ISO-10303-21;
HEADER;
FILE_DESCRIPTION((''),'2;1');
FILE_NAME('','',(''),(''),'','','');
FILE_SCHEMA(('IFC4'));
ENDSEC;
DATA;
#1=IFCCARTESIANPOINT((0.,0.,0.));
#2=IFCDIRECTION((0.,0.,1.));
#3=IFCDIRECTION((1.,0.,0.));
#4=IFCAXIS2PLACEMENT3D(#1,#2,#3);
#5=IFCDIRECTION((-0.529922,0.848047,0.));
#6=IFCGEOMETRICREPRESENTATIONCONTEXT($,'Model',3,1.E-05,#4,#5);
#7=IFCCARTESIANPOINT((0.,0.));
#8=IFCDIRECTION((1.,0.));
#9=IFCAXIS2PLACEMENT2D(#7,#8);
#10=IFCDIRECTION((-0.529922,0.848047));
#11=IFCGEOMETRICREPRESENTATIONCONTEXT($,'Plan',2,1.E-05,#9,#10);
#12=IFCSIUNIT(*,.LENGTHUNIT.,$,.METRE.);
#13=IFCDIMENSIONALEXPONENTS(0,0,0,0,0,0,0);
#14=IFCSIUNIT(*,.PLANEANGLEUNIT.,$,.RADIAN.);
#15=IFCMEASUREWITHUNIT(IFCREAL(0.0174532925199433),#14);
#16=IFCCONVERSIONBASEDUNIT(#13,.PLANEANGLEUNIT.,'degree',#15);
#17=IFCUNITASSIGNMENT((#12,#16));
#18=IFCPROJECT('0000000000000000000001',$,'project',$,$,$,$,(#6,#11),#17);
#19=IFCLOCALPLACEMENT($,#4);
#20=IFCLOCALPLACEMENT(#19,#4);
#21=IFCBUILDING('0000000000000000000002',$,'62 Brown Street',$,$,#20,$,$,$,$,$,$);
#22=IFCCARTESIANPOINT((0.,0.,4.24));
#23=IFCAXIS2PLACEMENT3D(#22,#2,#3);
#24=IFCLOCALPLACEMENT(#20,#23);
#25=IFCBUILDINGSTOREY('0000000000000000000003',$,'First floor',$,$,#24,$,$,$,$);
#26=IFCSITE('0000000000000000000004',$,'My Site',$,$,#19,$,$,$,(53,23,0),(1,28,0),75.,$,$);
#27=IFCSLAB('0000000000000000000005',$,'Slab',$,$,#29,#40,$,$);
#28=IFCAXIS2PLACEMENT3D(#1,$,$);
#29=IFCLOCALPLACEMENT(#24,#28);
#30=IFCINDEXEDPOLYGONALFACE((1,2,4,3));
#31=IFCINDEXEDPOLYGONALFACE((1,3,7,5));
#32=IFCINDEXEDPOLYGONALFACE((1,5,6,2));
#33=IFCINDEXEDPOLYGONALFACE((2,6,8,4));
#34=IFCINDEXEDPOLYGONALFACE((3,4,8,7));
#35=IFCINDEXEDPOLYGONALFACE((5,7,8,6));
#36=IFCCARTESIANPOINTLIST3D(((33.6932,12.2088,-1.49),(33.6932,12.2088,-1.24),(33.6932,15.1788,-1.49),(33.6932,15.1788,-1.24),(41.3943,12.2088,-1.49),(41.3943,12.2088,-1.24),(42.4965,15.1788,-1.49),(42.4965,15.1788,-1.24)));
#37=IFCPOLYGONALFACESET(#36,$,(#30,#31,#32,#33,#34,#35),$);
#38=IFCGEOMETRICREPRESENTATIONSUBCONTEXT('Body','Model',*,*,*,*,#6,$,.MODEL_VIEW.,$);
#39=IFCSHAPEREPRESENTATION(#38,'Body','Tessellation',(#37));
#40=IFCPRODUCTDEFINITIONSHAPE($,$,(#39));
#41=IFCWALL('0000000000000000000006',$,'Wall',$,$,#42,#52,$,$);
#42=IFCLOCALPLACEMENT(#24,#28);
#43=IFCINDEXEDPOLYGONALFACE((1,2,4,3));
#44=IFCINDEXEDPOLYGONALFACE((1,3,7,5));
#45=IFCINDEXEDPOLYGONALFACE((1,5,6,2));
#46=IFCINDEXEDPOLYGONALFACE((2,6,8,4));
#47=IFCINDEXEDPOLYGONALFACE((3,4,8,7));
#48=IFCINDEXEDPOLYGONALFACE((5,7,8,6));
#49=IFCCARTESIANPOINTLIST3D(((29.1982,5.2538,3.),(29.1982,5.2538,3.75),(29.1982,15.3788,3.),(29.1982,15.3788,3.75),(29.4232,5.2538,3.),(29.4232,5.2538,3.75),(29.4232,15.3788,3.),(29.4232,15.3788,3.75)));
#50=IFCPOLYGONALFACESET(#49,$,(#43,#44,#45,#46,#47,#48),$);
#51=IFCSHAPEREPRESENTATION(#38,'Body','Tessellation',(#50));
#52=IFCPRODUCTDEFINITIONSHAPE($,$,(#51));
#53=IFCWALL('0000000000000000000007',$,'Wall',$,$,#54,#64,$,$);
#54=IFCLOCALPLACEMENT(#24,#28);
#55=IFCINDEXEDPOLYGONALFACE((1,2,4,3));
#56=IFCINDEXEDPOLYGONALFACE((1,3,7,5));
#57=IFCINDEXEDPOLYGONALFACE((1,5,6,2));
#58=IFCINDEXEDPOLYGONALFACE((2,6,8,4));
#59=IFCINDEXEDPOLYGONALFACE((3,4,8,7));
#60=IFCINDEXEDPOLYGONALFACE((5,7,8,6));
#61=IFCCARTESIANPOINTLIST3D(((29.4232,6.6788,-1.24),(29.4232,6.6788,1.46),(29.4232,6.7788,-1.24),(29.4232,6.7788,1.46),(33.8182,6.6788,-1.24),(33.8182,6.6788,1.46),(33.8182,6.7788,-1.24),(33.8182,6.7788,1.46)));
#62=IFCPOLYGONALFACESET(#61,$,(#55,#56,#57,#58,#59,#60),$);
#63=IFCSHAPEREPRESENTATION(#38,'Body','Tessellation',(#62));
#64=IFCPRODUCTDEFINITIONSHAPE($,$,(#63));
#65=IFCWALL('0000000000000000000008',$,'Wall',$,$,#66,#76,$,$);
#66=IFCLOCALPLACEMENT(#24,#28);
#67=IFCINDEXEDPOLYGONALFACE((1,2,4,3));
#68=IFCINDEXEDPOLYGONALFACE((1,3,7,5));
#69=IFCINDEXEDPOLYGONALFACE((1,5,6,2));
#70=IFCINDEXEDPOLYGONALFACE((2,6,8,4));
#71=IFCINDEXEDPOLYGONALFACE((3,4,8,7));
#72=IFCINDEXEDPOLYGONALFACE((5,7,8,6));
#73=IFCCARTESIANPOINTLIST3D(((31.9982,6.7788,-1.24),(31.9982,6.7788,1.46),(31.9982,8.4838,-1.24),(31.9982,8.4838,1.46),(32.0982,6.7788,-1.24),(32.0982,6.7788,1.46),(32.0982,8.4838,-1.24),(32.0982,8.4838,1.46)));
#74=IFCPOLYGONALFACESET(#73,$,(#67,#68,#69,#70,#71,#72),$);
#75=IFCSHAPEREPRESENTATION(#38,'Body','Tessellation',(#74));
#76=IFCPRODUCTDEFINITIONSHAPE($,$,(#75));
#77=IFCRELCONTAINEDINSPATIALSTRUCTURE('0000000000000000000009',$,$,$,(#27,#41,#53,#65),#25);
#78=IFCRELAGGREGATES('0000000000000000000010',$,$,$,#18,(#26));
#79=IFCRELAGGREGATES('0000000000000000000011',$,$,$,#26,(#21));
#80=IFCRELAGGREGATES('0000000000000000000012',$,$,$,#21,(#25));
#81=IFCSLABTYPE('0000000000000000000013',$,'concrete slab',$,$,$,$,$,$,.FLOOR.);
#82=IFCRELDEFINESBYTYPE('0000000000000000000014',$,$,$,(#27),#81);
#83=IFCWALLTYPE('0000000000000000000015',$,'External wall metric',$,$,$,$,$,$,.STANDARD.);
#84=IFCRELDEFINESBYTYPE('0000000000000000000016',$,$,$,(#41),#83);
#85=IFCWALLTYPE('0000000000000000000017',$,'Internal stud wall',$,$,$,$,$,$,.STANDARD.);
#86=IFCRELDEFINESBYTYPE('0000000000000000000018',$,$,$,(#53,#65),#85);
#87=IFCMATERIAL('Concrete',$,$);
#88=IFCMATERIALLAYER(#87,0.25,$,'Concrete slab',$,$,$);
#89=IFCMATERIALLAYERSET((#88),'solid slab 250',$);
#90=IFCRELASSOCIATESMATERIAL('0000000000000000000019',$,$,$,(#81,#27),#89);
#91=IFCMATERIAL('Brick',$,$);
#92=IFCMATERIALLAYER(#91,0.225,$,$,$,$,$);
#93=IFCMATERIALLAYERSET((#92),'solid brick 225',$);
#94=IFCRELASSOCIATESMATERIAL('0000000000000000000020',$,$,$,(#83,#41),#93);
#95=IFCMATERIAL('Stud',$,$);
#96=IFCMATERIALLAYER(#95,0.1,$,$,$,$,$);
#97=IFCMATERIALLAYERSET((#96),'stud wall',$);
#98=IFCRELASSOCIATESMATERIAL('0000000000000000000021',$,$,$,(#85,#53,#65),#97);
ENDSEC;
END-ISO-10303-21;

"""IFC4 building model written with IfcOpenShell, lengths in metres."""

from ifc_helpers import new_model, entity, si_unit, converted_unit, direction, frame, origin_with_axes, origin_2d_with_axis, place, context, subcontext, project, spatial, line, indexed_curve, outline, extrude, material, layer, layer_set, layer_usage, type_object, element, save


model = new_model("IFC4")

# Units and contexts
model_context = context("Model", 3, precision=1e-05, world=origin_with_axes(), true_north=direction((-0.529922, 0.848047, 0.0)))
plan_context = context("Plan", 2, precision=1e-05, world=origin_2d_with_axis(), true_north=direction((-0.529922, 0.848047)))
body_context_1 = subcontext(model_context, "Body", "Model", "MODEL_VIEW")
ifc_project = project(units=[si_unit("LENGTHUNIT", "METRE"), converted_unit("PLANEANGLEUNIT", "degree", entity("IfcReal", 0.0174532925199433), si_unit("PLANEANGLEUNIT", "RADIAN"), dimensions=[0, 0, 0, 0, 0, 0, 0])], contexts=[model_context, plan_context])

# Site, building, storey
site_placement = place(None, origin_with_axes())
site = spatial("IfcSite", under=ifc_project, at=site_placement, Name="My Site", RefLatitude=(53, 23, 0), RefLongitude=(1, 28, 0), RefElevation=75.0)
building_placement = place(site_placement, origin_with_axes())
building = spatial("IfcBuilding", under=site, at=building_placement, Name="62 Brown Street")
storey_placement = place(building_placement, frame((0.0, 0.0, 4.24), z_axis=(0.0, 0.0, 1.0), x_axis=(1.0, 0.0, 0.0)))
storey = spatial("IfcBuildingStorey", under=building, at=storey_placement, Name="First floor")

# Slab
ifc_material_1 = material(Name="Concrete")
ifc_layer_1 = layer(ifc_material_1, 0.25, Name="Concrete slab")
ifc_layer_set_1 = layer_set([ifc_layer_1], Name="solid slab 250")
ifc_layer_usage_1 = layer_usage(ifc_layer_set_1, "AXIS3", "POSITIVE", 0.0)
slab_type = type_object("IfcSlabType", Name="concrete slab", PredefinedType="FLOOR", material=ifc_layer_set_1)
slab_1_placement = place(storey_placement, frame((33.6932, 12.2088, -1.49), z_axis=(0.0, 0.0, 1.0), x_axis=(1.0, 0.0, 0.0)))
element("IfcSlab", 1, at=slab_1_placement, inside=storey, type_object=slab_type, material=ifc_layer_usage_1, Name="Slab", context=body_context_1, shape_type="SweptSolid", body=[
    extrude(outline(indexed_curve([(8.8033, 2.97), (7.7011, 0.0), (0.0, 0.0), (0.0, 2.97)], segments=[line(4, 1), line(1, 2), line(2, 3), line(3, 4)], self_intersect=False)), None, (0.0, 0.0, 1.0), 0.25),
])

# Shared definitions
ifc_material_2 = material(Name="Brick")
ifc_layer_2 = layer(ifc_material_2, 0.225)
ifc_layer_set_2 = layer_set([ifc_layer_2], Name="solid brick 225")
wall_type_1 = type_object("IfcWallType", Name="External wall metric", PredefinedType="STANDARD", material=ifc_layer_set_2)

# Wall
ifc_layer_usage_2 = layer_usage(ifc_layer_set_2, "AXIS2", "POSITIVE", 0.0)
wall_1_placement = place(storey_placement, frame((29.4232, 5.2538, 3.0), z_axis=(0.0, 0.0, 1.0), x_axis=(0.0, 1.0, 0.0)))
element("IfcWall", 2, at=wall_1_placement, inside=storey, type_object=wall_type_1, material=ifc_layer_usage_2, Name="Wall", context=body_context_1, shape_type="SweptSolid", body=[
    extrude(outline(indexed_curve([(0.0, 0.0), (0.0, 0.225), (10.125, 0.225), (10.125, 0.0), (0.0, 0.0)], self_intersect=False)), origin_with_axes(), (0.0, 0.0, 1.0), 0.75),
])

# Shared definitions
ifc_material_3 = material(Name="Stud")
ifc_layer_3 = layer(ifc_material_3, 0.1)
ifc_layer_set_3 = layer_set([ifc_layer_3], Name="stud wall")
wall_type_2 = type_object("IfcWallType", Name="Internal stud wall", PredefinedType="STANDARD", material=ifc_layer_set_3)

# Walls
ifc_layer_usage_3 = layer_usage(ifc_layer_set_3, "AXIS2", "POSITIVE", 0.0)
wall_2_placement = place(storey_placement, frame((33.8182, 6.7788, -1.24), z_axis=(0.0, 0.0, 1.0), x_axis=(-1.0, 0.000001, 0.0)))
element("IfcWall", 3, at=wall_2_placement, inside=storey, type_object=wall_type_2, material=ifc_layer_usage_3, Name="Wall", context=body_context_1, shape_type="SweptSolid", body=[
    extrude(outline(indexed_curve([(0.0, 0.0), (0.0, 0.1), (4.395, 0.1), (4.395, 0.0), (0.0, 0.0)], self_intersect=False)), origin_with_axes(), (0.0, 0.0, 1.0), 2.7),
])
ifc_layer_usage_4 = layer_usage(ifc_layer_set_3, "AXIS2", "POSITIVE", 0.0)
wall_3_placement = place(storey_placement, frame((32.0982, 6.7788, -1.24), z_axis=(0.0, 0.0, 1.0), x_axis=(0.000001, 1.0, 0.0)))
element("IfcWall", 4, at=wall_3_placement, inside=storey, type_object=wall_type_2, material=ifc_layer_usage_4, Name="Wall", context=body_context_1, shape_type="SweptSolid", body=[
    extrude(outline(indexed_curve([(0.0, 0.0), (0.0, 0.1), (1.705, 0.1), (1.705, 0.0), (0.0, 0.0)], self_intersect=False)), origin_with_axes(), (0.0, 0.0, 1.0), 2.7),
])

save(model, "model.ifc")
